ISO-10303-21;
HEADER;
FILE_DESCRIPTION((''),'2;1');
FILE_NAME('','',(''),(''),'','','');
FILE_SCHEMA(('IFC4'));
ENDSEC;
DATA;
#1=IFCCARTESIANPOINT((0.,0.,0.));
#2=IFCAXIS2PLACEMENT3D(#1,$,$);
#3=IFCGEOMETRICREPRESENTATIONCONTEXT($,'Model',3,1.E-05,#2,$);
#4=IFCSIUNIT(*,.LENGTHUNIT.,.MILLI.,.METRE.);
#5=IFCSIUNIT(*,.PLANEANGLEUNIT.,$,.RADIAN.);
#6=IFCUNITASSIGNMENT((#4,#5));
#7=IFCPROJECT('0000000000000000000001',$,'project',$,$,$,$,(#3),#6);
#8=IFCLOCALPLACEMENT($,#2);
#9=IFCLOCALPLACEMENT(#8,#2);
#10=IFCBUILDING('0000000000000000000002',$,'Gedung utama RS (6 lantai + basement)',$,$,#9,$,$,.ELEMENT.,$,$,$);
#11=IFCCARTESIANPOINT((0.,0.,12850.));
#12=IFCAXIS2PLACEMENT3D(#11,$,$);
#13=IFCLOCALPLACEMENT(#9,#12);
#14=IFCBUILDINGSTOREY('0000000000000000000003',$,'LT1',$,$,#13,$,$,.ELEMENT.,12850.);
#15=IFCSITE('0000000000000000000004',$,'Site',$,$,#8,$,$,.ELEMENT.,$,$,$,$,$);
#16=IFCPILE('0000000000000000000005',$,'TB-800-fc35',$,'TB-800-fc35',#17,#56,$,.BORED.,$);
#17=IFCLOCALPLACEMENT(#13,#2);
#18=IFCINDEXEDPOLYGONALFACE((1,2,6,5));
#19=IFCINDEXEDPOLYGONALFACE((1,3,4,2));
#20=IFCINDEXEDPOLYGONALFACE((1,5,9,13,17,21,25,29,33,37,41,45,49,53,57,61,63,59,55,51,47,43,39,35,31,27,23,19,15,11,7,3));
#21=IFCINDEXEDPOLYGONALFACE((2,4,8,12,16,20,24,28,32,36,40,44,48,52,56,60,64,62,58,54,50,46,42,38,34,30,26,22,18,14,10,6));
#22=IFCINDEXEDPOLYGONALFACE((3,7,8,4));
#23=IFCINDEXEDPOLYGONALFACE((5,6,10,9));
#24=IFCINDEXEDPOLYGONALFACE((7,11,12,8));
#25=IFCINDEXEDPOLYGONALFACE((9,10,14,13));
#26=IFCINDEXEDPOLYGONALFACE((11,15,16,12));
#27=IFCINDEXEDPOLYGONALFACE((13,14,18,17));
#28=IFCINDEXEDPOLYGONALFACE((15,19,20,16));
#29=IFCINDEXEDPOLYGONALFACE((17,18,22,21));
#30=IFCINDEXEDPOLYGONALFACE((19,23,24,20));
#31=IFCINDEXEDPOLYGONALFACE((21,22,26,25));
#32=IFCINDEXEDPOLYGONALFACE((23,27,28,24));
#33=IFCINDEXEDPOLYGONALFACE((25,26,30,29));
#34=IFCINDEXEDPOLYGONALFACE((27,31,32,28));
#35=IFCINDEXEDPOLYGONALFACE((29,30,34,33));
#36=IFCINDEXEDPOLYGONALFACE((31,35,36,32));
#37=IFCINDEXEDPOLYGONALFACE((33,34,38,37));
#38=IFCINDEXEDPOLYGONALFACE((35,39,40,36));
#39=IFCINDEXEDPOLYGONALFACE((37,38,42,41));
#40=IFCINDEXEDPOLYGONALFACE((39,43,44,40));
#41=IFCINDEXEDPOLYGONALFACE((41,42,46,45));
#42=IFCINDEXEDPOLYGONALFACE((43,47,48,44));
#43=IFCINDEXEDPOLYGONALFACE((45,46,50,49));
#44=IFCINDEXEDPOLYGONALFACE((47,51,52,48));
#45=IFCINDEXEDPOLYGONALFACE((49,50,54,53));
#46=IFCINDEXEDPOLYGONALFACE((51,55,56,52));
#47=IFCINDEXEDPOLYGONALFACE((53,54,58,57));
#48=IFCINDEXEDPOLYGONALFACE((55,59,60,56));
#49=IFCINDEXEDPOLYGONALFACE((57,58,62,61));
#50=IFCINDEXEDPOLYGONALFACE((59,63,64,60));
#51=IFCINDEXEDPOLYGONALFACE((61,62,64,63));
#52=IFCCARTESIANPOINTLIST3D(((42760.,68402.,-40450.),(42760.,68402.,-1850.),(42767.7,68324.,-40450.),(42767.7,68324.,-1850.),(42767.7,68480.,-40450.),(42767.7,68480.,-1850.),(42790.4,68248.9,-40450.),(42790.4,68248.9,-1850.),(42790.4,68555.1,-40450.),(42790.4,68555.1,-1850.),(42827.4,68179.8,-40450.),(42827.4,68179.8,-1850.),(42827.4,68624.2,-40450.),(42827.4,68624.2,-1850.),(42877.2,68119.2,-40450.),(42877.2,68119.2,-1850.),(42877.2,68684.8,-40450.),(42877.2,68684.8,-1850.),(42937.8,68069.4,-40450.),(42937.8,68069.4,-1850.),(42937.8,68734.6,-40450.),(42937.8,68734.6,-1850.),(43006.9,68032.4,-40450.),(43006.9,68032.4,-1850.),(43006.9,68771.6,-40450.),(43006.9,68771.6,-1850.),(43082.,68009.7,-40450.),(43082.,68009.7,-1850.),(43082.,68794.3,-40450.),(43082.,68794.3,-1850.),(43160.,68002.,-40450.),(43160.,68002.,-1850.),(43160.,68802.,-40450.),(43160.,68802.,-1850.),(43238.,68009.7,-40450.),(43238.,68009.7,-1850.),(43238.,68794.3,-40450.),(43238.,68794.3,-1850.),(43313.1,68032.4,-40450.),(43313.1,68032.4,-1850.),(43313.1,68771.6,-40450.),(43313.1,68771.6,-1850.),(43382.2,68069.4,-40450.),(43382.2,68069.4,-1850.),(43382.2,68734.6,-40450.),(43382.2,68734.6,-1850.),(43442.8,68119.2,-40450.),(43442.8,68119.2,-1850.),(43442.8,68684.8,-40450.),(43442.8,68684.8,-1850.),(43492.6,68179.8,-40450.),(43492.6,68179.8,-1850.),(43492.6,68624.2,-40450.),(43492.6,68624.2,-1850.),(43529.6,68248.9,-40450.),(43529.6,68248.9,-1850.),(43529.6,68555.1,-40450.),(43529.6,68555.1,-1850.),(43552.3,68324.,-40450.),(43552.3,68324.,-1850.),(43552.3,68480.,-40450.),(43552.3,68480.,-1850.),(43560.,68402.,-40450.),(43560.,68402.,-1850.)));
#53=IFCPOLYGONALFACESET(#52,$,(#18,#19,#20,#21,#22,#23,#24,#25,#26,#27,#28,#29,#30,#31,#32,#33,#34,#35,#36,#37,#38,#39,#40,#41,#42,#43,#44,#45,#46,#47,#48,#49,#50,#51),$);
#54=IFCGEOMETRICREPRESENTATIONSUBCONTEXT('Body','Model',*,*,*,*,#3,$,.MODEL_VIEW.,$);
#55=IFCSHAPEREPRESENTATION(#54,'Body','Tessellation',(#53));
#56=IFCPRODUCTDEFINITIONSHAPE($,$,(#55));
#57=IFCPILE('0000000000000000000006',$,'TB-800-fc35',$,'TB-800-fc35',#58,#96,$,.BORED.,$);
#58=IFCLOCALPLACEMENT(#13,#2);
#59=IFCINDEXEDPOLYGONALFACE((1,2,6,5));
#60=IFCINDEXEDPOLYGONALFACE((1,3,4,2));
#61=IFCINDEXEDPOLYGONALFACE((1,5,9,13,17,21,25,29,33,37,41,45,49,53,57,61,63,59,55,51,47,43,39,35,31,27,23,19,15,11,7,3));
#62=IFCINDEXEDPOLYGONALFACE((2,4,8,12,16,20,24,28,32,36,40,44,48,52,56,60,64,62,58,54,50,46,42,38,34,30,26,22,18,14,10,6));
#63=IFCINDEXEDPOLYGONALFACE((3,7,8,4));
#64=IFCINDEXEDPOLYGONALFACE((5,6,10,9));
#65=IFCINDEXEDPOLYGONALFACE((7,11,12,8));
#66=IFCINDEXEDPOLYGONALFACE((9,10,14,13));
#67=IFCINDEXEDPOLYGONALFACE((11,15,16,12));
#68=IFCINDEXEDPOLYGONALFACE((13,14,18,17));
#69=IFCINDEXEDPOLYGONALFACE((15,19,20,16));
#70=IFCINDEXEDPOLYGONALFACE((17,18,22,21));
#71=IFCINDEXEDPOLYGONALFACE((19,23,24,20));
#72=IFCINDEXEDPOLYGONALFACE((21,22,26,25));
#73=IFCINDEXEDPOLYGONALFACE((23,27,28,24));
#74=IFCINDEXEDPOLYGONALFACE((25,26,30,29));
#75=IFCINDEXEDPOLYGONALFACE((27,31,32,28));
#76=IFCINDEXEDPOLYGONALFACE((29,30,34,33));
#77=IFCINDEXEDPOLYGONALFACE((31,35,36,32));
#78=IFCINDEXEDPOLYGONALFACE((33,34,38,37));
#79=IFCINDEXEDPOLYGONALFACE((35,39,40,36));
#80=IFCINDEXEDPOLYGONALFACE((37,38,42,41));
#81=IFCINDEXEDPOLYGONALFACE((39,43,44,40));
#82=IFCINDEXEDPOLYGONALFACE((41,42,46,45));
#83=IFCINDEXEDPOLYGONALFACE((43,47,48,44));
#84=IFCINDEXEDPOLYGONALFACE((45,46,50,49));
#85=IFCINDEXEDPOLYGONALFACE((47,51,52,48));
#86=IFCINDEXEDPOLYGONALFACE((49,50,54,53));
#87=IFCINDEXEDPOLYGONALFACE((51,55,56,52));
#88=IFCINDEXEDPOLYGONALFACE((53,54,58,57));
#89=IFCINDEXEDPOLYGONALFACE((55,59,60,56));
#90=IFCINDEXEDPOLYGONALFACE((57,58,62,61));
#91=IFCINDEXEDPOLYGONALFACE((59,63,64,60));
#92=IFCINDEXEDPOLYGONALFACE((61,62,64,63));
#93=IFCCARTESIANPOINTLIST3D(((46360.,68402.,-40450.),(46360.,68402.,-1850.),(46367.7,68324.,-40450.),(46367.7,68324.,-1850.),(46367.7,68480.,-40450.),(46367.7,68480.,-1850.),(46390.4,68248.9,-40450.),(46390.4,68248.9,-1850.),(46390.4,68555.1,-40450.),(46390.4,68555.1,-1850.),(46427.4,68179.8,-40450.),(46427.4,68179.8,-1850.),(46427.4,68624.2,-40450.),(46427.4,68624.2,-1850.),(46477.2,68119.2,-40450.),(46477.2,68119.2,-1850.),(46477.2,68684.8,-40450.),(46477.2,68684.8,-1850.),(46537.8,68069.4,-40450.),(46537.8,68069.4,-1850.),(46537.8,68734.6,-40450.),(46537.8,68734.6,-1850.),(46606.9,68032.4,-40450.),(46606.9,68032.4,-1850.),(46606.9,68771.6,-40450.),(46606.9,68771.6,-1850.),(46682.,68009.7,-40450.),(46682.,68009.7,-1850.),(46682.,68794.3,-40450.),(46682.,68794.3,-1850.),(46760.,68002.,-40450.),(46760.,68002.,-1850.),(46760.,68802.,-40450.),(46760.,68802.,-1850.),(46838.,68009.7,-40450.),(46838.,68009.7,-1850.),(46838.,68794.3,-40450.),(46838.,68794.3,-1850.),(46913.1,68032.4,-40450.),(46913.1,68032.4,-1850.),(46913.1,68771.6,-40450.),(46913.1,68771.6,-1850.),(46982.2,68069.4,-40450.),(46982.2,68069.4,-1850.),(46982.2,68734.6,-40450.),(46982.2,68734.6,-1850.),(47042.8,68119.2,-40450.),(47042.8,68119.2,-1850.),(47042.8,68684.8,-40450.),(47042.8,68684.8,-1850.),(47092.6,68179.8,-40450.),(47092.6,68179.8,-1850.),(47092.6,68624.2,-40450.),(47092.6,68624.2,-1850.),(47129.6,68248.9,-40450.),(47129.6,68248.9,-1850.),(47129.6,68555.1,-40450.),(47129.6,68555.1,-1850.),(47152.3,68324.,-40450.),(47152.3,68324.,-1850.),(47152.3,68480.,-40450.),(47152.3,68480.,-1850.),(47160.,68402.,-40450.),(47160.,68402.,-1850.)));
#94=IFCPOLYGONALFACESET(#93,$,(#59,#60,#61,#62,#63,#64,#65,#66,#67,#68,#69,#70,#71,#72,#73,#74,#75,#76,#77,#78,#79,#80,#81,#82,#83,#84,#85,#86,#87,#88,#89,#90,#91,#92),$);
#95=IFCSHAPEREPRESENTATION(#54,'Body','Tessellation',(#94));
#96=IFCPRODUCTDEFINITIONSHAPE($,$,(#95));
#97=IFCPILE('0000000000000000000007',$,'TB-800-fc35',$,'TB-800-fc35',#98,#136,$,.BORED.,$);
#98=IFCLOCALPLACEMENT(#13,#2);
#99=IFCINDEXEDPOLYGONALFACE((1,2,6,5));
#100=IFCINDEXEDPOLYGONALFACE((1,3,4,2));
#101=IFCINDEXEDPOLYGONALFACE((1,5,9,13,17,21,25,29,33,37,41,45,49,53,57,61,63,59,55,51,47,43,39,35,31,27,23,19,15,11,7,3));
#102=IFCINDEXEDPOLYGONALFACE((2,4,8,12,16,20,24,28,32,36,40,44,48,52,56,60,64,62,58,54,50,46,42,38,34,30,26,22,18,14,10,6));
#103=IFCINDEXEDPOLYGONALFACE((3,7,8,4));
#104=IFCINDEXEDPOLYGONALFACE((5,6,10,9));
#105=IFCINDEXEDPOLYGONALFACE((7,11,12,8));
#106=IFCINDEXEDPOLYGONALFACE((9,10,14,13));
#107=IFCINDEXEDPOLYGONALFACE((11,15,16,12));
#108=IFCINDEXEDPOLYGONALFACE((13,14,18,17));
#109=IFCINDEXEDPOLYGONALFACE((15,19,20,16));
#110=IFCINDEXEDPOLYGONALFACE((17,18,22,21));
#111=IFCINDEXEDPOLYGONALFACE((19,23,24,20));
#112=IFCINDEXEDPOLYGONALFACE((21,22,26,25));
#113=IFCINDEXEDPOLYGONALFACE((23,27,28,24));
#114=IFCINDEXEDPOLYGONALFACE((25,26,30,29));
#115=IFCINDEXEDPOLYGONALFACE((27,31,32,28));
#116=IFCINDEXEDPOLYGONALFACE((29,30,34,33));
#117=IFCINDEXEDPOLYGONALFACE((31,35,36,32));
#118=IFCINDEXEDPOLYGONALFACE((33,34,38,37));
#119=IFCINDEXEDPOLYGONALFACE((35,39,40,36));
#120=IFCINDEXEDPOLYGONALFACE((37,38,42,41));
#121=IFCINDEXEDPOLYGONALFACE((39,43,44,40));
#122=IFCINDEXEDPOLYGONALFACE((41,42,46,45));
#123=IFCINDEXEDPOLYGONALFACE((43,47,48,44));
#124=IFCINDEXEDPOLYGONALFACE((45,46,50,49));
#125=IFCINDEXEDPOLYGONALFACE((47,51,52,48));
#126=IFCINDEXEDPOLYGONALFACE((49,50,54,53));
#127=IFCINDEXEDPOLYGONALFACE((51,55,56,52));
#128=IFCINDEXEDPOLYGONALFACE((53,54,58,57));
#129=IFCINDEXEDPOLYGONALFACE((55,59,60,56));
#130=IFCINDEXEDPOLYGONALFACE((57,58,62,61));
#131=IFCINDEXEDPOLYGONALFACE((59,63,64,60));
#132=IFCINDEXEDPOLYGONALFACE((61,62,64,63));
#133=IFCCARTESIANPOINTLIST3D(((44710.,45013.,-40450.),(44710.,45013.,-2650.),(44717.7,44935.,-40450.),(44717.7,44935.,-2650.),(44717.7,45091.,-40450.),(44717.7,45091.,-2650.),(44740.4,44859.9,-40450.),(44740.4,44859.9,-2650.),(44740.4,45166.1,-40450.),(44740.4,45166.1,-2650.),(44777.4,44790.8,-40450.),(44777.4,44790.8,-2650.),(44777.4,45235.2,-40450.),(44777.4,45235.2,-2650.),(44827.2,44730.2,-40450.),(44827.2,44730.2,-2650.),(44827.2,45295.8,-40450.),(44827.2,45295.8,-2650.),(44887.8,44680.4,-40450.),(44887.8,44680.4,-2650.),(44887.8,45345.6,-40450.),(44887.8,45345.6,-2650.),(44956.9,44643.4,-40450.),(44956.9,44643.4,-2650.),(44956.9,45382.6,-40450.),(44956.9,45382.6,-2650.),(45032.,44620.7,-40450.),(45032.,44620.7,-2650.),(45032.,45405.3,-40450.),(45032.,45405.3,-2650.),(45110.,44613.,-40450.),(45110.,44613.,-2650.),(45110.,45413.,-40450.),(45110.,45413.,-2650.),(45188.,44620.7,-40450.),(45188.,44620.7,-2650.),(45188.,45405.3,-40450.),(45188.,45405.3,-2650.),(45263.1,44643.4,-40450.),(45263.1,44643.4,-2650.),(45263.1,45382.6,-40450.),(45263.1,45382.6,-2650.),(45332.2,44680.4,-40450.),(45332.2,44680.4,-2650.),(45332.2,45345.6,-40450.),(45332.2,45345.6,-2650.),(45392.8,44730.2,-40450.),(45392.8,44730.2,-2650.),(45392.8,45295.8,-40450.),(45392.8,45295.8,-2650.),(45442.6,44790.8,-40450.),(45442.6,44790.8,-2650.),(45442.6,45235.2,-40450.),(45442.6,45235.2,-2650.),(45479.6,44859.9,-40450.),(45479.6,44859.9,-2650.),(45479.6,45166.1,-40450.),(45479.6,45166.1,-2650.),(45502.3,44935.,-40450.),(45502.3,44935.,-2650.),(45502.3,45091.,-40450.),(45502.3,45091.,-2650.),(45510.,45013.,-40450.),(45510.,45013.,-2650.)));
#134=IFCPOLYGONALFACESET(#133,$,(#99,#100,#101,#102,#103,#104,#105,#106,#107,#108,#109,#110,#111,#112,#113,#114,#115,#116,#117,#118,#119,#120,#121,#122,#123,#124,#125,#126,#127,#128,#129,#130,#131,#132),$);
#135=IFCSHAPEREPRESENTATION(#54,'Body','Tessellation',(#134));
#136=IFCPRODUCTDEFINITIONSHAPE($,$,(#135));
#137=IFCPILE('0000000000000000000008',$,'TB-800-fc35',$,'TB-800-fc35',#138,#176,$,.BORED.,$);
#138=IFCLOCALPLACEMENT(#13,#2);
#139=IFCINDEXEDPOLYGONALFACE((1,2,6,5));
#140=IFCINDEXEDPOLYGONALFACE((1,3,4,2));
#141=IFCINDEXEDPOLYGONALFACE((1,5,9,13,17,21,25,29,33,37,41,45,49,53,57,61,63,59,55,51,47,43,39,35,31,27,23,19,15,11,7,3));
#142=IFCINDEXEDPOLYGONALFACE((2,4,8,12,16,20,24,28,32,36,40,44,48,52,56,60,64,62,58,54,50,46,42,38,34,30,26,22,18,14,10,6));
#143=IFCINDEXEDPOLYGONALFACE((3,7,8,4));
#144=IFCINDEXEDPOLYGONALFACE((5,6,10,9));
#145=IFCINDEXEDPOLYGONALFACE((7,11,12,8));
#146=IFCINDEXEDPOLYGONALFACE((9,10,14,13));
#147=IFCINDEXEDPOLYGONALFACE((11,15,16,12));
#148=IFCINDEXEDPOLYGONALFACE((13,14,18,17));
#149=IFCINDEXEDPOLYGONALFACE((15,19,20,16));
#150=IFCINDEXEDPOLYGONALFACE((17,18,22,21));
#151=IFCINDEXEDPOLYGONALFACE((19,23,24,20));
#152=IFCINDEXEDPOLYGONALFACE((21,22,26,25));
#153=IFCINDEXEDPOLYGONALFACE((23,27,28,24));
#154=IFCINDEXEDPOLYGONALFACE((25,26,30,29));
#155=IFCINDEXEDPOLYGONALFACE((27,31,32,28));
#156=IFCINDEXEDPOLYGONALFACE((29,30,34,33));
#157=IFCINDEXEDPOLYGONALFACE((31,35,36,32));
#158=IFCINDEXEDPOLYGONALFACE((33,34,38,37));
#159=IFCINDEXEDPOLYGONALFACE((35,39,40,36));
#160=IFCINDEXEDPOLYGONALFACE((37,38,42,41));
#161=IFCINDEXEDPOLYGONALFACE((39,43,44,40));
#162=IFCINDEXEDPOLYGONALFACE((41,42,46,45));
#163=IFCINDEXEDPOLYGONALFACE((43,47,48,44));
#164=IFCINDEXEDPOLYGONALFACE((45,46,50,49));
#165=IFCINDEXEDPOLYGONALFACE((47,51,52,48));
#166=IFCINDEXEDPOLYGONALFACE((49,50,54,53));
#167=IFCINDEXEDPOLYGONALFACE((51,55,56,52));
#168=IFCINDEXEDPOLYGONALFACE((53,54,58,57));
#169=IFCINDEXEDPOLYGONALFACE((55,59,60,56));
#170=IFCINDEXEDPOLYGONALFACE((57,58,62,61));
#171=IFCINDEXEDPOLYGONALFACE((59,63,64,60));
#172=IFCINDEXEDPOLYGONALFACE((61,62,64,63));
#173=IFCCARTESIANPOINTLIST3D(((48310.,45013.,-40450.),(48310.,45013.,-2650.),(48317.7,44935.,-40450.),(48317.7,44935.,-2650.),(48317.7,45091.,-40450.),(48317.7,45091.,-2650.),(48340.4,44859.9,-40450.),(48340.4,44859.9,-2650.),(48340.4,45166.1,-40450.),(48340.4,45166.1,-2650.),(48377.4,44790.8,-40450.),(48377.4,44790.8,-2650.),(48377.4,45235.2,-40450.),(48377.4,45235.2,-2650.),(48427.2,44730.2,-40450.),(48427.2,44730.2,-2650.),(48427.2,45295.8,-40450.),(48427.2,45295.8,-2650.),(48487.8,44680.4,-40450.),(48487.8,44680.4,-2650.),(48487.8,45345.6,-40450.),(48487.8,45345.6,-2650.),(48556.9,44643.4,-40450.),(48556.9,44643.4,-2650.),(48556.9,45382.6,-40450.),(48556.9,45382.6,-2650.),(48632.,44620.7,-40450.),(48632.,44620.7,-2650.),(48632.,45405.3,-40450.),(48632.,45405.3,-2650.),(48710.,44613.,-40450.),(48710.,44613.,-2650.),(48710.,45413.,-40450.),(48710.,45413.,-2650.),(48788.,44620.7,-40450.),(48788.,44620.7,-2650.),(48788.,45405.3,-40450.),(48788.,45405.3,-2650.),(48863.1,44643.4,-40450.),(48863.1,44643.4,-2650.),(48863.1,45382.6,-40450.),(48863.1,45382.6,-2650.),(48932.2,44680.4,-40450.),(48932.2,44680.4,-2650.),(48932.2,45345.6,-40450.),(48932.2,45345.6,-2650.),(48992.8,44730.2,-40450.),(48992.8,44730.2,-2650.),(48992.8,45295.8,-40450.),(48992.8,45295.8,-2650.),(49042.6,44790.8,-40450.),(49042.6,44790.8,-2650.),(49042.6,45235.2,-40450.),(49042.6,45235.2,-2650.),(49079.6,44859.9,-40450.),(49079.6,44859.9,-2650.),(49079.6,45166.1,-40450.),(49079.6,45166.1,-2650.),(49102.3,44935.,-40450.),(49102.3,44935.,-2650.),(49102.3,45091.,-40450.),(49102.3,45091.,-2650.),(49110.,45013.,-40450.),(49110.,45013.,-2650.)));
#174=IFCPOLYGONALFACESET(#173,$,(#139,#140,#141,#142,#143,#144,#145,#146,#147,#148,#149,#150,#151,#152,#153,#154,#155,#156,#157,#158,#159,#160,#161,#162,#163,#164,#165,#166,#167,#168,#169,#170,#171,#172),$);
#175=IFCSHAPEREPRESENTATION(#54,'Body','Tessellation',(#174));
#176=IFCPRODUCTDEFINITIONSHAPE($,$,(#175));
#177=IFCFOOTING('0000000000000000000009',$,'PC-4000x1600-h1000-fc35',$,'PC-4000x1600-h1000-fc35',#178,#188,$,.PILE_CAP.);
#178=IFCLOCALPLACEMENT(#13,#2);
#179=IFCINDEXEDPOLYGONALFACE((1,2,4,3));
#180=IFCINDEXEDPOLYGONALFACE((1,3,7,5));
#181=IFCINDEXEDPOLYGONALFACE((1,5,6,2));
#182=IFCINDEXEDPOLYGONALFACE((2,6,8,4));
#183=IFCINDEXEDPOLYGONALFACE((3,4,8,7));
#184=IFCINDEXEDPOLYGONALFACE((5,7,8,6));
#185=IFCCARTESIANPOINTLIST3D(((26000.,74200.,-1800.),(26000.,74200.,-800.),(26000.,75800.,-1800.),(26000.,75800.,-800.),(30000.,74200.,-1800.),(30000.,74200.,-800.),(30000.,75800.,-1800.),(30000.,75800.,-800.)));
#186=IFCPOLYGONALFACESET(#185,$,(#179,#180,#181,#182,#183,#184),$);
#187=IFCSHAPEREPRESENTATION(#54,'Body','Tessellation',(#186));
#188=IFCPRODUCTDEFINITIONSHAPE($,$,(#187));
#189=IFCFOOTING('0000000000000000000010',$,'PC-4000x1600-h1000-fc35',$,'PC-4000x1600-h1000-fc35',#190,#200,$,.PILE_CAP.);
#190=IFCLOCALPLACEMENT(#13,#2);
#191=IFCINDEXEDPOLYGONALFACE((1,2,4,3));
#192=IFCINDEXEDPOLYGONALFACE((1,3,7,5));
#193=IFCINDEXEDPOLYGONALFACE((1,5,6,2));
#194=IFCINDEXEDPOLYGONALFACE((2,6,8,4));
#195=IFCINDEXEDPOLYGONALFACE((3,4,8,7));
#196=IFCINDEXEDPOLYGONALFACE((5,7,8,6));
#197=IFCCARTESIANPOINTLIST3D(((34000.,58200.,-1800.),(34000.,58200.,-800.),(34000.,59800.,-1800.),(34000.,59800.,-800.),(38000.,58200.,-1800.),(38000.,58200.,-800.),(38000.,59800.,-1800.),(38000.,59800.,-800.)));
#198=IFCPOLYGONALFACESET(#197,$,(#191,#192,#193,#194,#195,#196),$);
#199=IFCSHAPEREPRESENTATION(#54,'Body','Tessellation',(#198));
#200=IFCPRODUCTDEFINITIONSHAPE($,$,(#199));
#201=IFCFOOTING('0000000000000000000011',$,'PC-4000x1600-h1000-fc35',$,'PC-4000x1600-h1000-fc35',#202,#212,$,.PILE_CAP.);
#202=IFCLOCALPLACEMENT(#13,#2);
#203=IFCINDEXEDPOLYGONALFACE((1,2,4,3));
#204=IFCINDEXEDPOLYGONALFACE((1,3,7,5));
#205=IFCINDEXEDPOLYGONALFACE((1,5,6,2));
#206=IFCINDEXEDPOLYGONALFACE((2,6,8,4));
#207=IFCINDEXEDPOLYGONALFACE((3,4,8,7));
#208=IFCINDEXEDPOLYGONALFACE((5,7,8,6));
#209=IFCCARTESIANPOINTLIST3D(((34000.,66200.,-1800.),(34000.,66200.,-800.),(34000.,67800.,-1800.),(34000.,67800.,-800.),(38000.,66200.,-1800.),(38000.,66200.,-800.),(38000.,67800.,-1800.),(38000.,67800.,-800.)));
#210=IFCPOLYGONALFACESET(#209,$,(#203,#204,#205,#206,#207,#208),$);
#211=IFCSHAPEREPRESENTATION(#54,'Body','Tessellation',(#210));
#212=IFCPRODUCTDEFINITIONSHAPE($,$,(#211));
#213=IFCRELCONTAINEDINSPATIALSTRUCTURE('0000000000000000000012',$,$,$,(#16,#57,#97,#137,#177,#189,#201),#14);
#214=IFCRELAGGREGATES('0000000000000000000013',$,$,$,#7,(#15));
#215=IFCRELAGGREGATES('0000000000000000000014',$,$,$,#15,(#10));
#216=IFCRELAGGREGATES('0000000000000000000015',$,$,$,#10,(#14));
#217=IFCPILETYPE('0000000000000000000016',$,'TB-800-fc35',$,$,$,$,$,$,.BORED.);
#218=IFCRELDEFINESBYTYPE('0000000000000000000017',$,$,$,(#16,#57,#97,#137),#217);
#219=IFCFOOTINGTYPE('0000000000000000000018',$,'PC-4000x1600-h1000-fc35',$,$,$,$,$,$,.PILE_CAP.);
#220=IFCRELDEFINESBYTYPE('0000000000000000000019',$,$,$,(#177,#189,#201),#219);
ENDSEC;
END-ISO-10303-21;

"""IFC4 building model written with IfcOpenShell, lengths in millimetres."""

from ifc_helpers import new_model, si_unit, frame, origin, origin_2d, place, context, subcontext, project, spatial, rectangle, circle, extrude, material_profile, profile_set, profile_usage, type_object, element, save


model = new_model("IFC4")

# Units and contexts
model_context = context("Model", 3, precision=1e-05, world=origin())
body_context = subcontext(model_context, "Body", "Model", "MODEL_VIEW")
ifc_project = project(units=[si_unit("LENGTHUNIT", "METRE", prefix="MILLI"), si_unit("PLANEANGLEUNIT", "RADIAN")], contexts=[model_context])

# Site, building, storey
site_placement = place(None, origin())
site = spatial("IfcSite", under=ifc_project, at=site_placement, Name="Site", CompositionType="ELEMENT")
building_placement = place(site_placement, origin())
building = spatial("IfcBuilding", under=site, at=building_placement, Name="Gedung utama RS (6 lantai + basement)", CompositionType="ELEMENT")
storey_placement = place(building_placement, frame((0.0, 0.0, 12850.0)))
storey = spatial("IfcBuildingStorey", under=building, at=storey_placement, Name="LT1", CompositionType="ELEMENT", Elevation=12850.0)

# Piles
ifc_material_profile_1 = material_profile(None, circle(Radius=400.0, at=origin_2d()), Name="TB-800-fc35")
ifc_profile_set_1 = profile_set([ifc_material_profile_1], Name="TB-800-fc35")
ifc_profile_usage_1 = profile_usage(ifc_profile_set_1, cardinal=5)
pile_type = type_object("IfcPileType", Name="TB-800-fc35", PredefinedType="BORED", material=ifc_profile_set_1)
for number, where, z_axis, x_axis, name in (
    (1, (43160.0, 68402.0, -40450.0), (0.0, 0.0, 1.0), (1.0, 0.0, 0.0), "TB-800-fc35"),
    (2, (46760.0, 68402.0, -40450.0), (0.0, 0.0, 1.0), (1.0, 0.0, 0.0), "TB-800-fc35"),
):
    element("IfcPile", number, at=place(storey_placement, frame(where, z_axis=z_axis, x_axis=x_axis)), inside=storey, type_object=pile_type, material=ifc_profile_usage_1, Name=name, ObjectType="TB-800-fc35", PredefinedType="BORED", context=body_context, shape_type="SweptSolid", body=[
        extrude(circle(Radius=400.0, at=origin_2d()), origin(), (0.0, 0.0, 1.0), 38600.0),
    ])
for number, where, z_axis, x_axis, name in (
    (3, (45110.0, 45013.0, -40450.0), (0.0, 0.0, 1.0), (1.0, 0.0, 0.0), "TB-800-fc35"),
    (4, (48710.0, 45013.0, -40450.0), (0.0, 0.0, 1.0), (1.0, 0.0, 0.0), "TB-800-fc35"),
):
    element("IfcPile", number, at=place(storey_placement, frame(where, z_axis=z_axis, x_axis=x_axis)), inside=storey, type_object=pile_type, material=ifc_profile_usage_1, Name=name, ObjectType="TB-800-fc35", PredefinedType="BORED", context=body_context, shape_type="SweptSolid", body=[
        extrude(circle(Radius=400.0, at=origin_2d()), origin(), (0.0, 0.0, 1.0), 37800.0),
    ])

# Footings
ifc_material_profile_2 = material_profile(None, rectangle(XDim=4000.0, YDim=1600.0, at=origin_2d()), Name="PC-4000x1600-h1000-fc35")
ifc_profile_set_2 = profile_set([ifc_material_profile_2], Name="PC-4000x1600-h1000-fc35")
ifc_profile_usage_2 = profile_usage(ifc_profile_set_2, cardinal=5)
footing_type_1 = type_object("IfcFootingType", Name="PC-4000x1600-h1000-fc35", PredefinedType="PILE_CAP", material=ifc_profile_set_2)
for number, where, z_axis, x_axis, name in (
    (5, (28000.0, 75000.0, -1800.0), (0.0, 0.0, 1.0), (1.0, 0.0, 0.0), "PC-4000x1600-h1000-fc35"),
    (6, (36000.0, 59000.0, -1800.0), (0.0, 0.0, 1.0), (1.0, 0.0, 0.0), "PC-4000x1600-h1000-fc35"),
    (7, (36000.0, 67000.0, -1800.0), (0.0, 0.0, 1.0), (1.0, 0.0, 0.0), "PC-4000x1600-h1000-fc35"),
):
    element("IfcFooting", number, at=place(storey_placement, frame(where, z_axis=z_axis, x_axis=x_axis)), inside=storey, type_object=footing_type_1, material=ifc_profile_usage_2, Name=name, ObjectType="PC-4000x1600-h1000-fc35", PredefinedType="PILE_CAP", context=body_context, shape_type="SweptSolid", body=[
        extrude(rectangle(XDim=4000.0, YDim=1600.0, at=origin_2d()), origin(), (0.0, 0.0, 1.0), 1000.0),
    ])

save(model, "model.ifc")
